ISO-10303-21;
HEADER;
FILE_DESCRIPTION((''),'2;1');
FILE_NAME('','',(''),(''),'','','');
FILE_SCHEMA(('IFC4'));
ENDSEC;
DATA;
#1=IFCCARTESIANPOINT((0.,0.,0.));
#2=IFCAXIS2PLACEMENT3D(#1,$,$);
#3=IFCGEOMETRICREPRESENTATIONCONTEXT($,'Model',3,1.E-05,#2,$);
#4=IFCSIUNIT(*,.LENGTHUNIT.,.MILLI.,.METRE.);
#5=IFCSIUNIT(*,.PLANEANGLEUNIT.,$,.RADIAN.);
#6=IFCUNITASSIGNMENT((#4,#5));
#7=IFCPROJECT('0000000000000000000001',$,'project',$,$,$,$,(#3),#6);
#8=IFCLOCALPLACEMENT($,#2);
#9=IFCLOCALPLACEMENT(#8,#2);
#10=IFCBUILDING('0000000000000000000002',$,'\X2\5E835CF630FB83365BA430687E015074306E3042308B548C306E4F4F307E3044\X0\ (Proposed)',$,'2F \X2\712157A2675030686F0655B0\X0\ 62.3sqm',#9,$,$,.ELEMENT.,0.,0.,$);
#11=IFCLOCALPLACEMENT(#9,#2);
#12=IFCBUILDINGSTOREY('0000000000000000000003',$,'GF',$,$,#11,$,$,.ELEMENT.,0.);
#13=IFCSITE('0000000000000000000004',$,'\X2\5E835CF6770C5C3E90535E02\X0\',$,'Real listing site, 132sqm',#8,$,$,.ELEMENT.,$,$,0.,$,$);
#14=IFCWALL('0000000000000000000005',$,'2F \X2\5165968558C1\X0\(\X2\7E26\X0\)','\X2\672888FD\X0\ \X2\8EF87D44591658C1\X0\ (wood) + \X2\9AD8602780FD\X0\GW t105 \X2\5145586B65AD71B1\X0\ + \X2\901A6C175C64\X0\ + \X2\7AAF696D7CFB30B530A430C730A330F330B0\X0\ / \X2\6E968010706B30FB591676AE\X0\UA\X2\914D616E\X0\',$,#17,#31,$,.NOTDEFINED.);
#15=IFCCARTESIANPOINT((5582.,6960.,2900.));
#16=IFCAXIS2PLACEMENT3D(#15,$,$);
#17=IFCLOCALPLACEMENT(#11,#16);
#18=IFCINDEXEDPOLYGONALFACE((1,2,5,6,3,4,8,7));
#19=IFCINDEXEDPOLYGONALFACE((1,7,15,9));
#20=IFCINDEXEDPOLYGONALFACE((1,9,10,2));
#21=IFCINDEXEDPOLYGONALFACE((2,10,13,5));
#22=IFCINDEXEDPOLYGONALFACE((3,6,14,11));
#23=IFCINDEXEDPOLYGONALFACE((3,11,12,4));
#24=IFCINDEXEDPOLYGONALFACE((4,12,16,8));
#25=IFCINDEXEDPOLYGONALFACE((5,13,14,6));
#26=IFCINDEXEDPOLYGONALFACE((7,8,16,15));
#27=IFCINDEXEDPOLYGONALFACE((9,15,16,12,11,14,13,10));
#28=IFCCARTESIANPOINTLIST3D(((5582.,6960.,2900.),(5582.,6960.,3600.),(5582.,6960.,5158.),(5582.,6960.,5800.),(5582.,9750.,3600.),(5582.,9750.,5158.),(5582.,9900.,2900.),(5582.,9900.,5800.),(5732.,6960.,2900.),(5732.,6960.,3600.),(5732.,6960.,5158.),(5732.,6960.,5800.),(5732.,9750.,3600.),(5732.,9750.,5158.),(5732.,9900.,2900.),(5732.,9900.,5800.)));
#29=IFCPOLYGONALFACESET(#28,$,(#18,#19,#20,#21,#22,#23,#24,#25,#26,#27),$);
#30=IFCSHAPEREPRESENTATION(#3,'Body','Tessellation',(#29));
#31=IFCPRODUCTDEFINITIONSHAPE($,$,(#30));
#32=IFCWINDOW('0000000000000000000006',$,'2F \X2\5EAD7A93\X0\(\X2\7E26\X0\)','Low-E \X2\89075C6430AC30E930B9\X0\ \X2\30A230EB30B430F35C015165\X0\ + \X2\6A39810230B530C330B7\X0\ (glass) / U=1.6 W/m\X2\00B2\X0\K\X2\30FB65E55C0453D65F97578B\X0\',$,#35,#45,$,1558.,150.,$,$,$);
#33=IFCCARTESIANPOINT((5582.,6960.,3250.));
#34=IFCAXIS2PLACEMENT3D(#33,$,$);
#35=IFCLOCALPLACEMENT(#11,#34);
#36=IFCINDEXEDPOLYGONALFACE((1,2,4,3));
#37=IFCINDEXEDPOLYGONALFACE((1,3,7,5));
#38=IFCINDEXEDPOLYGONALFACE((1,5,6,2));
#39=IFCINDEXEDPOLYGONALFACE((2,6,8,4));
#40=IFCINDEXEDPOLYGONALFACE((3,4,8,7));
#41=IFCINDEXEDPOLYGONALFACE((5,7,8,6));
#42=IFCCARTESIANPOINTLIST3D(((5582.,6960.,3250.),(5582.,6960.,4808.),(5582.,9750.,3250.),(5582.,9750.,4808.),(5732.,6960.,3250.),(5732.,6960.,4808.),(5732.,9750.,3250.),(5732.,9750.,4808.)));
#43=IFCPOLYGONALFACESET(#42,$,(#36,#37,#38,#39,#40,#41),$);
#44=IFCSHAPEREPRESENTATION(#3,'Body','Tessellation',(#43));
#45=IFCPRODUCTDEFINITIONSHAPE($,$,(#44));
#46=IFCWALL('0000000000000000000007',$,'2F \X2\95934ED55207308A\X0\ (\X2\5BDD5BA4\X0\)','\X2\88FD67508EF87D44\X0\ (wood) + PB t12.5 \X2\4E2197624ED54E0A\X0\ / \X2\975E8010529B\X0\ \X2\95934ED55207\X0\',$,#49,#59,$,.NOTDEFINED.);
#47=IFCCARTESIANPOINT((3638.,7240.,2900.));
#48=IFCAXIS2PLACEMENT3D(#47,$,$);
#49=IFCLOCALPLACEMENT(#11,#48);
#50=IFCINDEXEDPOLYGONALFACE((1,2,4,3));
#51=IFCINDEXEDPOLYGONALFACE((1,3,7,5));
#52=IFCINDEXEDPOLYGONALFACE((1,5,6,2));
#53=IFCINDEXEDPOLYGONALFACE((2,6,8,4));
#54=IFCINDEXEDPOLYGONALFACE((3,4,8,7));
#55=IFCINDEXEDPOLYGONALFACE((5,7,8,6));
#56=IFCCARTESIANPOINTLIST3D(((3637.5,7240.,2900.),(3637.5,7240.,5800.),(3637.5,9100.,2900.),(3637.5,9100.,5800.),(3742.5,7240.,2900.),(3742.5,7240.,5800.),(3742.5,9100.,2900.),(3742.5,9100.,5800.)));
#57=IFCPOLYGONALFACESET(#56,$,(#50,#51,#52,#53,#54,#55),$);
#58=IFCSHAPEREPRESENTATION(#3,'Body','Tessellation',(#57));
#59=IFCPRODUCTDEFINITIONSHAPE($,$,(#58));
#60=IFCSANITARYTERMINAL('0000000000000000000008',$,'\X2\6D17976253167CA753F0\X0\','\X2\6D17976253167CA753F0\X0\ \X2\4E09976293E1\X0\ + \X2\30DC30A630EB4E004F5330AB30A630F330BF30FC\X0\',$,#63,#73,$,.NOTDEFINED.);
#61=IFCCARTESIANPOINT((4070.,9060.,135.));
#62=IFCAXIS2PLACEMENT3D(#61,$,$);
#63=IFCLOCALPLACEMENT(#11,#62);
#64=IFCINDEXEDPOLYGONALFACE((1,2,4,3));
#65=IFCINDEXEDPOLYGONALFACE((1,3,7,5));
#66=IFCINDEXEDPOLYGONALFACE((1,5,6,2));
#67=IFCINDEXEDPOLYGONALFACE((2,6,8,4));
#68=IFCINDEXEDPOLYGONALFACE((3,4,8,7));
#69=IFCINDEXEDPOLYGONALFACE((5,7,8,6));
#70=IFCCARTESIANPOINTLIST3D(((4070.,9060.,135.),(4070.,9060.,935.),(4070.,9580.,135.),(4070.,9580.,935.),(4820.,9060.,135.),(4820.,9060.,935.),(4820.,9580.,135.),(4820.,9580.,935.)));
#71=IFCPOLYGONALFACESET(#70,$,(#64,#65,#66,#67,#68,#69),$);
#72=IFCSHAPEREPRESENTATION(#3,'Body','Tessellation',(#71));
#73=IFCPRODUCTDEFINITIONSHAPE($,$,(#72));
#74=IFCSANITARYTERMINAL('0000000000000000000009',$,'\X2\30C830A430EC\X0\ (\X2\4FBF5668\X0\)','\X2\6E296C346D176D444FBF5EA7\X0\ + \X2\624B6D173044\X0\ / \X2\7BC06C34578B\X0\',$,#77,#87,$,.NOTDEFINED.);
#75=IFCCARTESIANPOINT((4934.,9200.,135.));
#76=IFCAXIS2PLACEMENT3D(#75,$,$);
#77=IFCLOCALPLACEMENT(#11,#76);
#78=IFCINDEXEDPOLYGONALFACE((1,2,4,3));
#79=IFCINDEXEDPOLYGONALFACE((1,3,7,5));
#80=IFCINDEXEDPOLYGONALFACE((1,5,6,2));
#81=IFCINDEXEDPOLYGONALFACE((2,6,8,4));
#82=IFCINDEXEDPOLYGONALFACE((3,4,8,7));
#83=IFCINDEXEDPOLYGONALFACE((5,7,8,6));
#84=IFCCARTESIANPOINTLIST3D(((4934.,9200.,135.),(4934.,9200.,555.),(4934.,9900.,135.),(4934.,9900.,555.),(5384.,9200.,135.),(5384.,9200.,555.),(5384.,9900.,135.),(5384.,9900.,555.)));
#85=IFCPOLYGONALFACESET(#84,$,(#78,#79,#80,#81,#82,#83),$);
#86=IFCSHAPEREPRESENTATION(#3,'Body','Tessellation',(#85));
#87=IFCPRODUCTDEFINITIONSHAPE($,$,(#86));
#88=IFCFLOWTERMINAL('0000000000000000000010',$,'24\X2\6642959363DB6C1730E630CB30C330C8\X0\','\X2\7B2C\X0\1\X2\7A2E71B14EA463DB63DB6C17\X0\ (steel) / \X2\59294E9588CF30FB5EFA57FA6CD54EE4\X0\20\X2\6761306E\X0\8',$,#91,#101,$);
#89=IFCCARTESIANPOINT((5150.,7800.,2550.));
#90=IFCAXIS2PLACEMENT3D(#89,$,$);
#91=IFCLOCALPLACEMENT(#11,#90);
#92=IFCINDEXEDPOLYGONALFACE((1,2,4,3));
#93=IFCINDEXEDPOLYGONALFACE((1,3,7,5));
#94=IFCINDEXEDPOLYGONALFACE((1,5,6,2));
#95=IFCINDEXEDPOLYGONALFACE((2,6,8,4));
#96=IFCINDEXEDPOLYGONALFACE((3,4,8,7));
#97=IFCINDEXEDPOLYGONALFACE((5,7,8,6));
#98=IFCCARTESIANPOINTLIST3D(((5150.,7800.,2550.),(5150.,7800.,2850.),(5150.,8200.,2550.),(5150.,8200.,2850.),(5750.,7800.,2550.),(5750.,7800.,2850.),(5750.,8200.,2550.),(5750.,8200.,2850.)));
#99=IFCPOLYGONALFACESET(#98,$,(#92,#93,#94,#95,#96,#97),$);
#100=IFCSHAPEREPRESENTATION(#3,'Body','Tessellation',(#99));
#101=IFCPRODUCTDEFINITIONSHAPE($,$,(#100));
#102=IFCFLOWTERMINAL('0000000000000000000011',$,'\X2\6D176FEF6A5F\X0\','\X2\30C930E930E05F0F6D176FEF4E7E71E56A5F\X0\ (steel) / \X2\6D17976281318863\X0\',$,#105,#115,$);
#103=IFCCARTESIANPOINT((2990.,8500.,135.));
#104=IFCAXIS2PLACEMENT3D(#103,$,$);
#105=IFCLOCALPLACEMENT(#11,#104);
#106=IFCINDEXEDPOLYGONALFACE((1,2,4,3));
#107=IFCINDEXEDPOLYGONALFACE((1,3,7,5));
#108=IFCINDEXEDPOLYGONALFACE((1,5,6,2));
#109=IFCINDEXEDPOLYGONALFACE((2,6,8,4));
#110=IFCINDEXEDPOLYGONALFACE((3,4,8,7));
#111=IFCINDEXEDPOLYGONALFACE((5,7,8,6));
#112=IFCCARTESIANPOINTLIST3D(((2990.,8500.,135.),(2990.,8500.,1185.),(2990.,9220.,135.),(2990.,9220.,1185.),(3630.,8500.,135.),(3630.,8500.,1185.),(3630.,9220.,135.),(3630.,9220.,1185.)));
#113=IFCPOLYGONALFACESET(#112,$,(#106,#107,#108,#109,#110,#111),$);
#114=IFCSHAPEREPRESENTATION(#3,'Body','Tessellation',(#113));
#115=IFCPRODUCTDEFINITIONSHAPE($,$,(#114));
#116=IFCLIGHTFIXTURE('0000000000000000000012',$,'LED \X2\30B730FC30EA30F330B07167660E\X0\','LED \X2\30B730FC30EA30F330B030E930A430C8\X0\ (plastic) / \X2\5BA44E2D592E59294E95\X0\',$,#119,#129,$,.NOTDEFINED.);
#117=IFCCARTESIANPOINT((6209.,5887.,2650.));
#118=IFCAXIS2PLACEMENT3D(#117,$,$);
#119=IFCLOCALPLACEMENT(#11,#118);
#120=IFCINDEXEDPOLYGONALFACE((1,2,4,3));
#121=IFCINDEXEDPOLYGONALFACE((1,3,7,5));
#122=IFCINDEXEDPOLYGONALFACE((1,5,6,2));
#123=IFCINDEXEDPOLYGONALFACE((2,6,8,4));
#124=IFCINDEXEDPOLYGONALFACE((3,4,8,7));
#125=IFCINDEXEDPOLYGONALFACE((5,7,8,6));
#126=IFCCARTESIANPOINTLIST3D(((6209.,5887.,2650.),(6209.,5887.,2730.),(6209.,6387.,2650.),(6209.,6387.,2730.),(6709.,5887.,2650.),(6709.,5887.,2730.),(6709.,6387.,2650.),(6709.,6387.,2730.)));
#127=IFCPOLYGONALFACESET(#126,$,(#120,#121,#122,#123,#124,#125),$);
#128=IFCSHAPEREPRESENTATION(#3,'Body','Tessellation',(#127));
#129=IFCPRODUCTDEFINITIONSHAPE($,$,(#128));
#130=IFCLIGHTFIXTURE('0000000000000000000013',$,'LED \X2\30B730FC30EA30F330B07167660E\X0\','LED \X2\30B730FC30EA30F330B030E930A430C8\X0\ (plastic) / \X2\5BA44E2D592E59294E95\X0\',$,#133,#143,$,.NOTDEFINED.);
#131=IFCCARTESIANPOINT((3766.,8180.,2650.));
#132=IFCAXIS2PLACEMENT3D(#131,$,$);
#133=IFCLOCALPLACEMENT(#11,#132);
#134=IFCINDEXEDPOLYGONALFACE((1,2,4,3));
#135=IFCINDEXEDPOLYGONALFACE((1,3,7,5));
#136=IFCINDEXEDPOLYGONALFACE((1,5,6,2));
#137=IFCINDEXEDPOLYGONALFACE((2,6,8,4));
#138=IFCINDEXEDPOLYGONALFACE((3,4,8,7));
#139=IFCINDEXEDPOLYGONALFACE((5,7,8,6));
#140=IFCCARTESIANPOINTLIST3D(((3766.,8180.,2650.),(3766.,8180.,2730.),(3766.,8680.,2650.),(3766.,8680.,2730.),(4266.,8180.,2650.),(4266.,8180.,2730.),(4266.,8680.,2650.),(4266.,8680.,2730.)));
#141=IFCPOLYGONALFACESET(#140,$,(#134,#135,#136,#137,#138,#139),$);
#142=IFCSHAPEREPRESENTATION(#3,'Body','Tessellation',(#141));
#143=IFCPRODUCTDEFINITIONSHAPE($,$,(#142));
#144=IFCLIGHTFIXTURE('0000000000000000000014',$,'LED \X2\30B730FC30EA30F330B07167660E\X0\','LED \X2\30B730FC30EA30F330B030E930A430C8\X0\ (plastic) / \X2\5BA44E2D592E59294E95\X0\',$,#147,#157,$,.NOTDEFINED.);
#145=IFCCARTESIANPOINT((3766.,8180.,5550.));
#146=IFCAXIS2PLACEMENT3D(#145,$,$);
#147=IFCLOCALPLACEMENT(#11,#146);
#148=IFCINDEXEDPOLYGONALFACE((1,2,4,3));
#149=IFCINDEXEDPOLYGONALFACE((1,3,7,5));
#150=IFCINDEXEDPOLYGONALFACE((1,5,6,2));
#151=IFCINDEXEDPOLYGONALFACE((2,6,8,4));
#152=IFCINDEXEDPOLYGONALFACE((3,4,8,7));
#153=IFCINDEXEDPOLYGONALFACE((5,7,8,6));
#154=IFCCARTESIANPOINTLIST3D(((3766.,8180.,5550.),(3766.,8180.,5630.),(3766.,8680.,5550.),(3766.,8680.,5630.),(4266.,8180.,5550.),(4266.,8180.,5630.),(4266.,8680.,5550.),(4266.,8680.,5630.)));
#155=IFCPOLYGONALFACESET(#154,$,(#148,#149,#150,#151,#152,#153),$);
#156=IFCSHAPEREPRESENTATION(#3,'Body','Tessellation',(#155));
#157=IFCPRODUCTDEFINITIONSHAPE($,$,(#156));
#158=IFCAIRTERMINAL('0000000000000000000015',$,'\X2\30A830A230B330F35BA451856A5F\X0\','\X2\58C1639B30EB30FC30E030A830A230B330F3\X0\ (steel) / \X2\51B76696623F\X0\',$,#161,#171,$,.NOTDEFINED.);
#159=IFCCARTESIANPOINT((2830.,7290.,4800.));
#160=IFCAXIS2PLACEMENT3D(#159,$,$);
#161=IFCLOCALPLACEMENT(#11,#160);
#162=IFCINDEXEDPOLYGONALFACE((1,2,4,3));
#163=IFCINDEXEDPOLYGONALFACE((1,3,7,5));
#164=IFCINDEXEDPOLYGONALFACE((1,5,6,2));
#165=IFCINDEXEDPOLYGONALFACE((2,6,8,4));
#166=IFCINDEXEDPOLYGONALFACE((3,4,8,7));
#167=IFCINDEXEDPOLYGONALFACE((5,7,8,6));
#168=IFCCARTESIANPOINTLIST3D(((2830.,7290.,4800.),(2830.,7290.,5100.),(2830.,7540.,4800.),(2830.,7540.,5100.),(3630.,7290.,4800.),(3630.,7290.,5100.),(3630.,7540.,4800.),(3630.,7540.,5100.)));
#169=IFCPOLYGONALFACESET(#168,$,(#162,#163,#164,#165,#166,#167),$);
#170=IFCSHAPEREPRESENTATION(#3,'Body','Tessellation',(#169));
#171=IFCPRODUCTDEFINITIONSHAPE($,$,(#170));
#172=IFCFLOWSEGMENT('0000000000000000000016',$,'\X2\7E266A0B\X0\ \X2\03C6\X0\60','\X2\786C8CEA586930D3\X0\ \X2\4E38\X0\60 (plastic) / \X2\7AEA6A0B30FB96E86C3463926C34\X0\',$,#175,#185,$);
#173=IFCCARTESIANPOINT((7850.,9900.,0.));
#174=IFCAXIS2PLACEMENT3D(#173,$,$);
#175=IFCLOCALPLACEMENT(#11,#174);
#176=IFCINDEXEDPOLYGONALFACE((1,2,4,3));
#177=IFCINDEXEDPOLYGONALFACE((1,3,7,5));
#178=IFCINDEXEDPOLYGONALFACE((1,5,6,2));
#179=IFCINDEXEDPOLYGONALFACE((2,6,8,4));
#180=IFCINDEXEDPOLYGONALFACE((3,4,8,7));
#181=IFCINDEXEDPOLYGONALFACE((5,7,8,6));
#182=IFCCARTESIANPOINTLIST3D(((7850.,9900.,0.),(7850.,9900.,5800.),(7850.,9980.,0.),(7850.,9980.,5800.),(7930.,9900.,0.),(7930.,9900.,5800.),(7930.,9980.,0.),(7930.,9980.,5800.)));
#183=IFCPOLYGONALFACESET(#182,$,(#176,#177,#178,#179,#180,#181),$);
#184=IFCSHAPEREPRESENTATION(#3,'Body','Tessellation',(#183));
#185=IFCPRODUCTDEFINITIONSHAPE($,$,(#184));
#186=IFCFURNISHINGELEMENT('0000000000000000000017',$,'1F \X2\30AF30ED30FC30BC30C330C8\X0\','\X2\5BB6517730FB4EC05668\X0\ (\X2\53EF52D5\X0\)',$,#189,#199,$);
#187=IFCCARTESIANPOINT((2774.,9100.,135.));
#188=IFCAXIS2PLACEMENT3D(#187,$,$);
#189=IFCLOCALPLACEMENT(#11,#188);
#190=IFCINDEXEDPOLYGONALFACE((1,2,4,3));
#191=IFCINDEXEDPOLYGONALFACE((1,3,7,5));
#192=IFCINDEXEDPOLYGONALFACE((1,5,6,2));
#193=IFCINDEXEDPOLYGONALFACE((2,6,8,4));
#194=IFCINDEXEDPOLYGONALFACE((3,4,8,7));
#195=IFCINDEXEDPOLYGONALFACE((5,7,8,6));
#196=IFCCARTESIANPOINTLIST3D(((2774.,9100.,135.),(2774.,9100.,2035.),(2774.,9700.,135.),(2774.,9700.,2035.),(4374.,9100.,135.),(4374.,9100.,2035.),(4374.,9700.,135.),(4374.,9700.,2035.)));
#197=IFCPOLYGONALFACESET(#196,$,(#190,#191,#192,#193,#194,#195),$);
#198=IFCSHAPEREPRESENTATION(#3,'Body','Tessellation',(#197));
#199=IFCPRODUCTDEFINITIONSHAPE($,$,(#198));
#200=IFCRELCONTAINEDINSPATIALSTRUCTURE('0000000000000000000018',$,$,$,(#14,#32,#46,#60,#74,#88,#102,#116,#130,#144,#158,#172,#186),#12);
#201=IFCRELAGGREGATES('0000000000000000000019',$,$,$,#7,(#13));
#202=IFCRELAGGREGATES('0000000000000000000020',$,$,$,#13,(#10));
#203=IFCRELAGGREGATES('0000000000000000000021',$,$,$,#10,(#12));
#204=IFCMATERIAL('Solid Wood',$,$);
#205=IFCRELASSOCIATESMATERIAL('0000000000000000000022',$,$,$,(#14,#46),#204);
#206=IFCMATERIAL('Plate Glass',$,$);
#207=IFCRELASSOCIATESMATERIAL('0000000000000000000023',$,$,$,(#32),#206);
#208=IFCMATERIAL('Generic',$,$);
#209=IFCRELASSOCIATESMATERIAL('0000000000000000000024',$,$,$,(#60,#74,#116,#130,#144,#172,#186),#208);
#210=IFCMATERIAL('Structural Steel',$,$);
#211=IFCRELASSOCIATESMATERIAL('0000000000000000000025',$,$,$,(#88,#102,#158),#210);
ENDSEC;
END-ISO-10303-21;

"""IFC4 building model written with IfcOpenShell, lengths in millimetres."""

from ifc_helpers import new_model, si_unit, frame, frame_2d, origin, place, context, project, spatial, rectangle, extrude, material, element, fill, save


model = new_model("IFC4")

# Units and contexts
model_context = context("Model", 3, precision=1e-05, world=origin())
ifc_project = project(units=[si_unit("LENGTHUNIT", "METRE", prefix="MILLI"), si_unit("PLANEANGLEUNIT", "RADIAN")], contexts=[model_context])

# Site, building, storey
site_placement = place(None, origin())
site = spatial("IfcSite", under=ifc_project, at=site_placement, Name="広島県尾道市", ObjectType="Real listing site, 132sqm", CompositionType="ELEMENT", RefElevation=0.0)
building_placement = place(site_placement, origin())
building = spatial("IfcBuilding", under=site, at=building_placement, Name="広島・茶室と縁側のある和の住まい (Proposed)", ObjectType="2F 無垢材と漆喰 62.3sqm", CompositionType="ELEMENT", ElevationOfRefHeight=0.0, ElevationOfTerrain=0.0)
storey_placement = place(building_placement, origin())
storey = spatial("IfcBuildingStorey", under=building, at=storey_placement, Name="GF", CompositionType="ELEMENT", Elevation=0.0)

# Shared definitions
ifc_material_1 = material(Name="Solid Wood")

# Shared definitions
ifc_material_2 = material(Name="Plate Glass")

# Wall, opening, window
wall_1_placement = place(storey_placement, frame((5582.0, 6960.0, 2900.0)))
wall_1 = element("IfcWall", 1, at=wall_1_placement, inside=storey, material=ifc_material_1, Name="2F 入隅壁(縦)", Description="木製 軸組外壁 (wood) + 高性能GW t105 充填断熱 + 通気層 + 窯業系サイディング / 準耐火・外皮UA配慮", PredefinedType="NOTDEFINED", context=model_context, shape_type="SweptSolid", body=[
    extrude(rectangle(XDim=150.0, YDim=2940.0, at=frame_2d((75.0, 1470.0))), frame((5582.0, 6960.0, 2900.0)), (0.0, 0.0, 1.0), 2900.0),
])
opening_1_placement = place(storey_placement, frame((5582.0, 6960.0, 3250.0)))
opening_1 = element("IfcOpeningElement", 2, at=opening_1_placement, cuts=wall_1, PredefinedType="NOTDEFINED", context=model_context, shape_type="SweptSolid", body=[
    extrude(rectangle(XDim=150.0, YDim=2790.0, at=frame_2d((75.0, 1395.0))), frame((5582.0, 6960.0, 3250.0)), (0.0, 0.0, 1.0), 1558.0),
])
window_1_placement = place(storey_placement, frame((5582.0, 6960.0, 3250.0)))
window_1 = element("IfcWindow", 3, at=window_1_placement, inside=storey, material=ifc_material_2, Name="2F 庭窓(縦)", Description="Low-E 複層ガラス アルゴン封入 + 樹脂サッシ (glass) / U=1.6 W/m²K・日射取得型", OverallHeight=1558.0, OverallWidth=150.0, context=model_context, shape_type="SweptSolid", body=[
    extrude(rectangle(XDim=150.0, YDim=2790.0, at=frame_2d((75.0, 1395.0))), frame((5582.0, 6960.0, 3250.0)), (0.0, 0.0, 1.0), 1558.0),
])
fill(opening_1, window_1)

# Wall
wall_2_placement = place(storey_placement, frame((3638.0, 7240.0, 2900.0)))
element("IfcWall", 4, at=wall_2_placement, inside=storey, material=ifc_material_1, Name="2F 間仕切り (寝室)", Description="製材軸組 (wood) + PB t12.5 両面仕上 / 非耐力 間仕切", PredefinedType="NOTDEFINED", context=model_context, shape_type="SweptSolid", body=[
    extrude(rectangle(XDim=105.0, YDim=1860.0, at=frame_2d((52.0, 930.0))), frame((3638.0, 7240.0, 2900.0)), (0.0, 0.0, 1.0), 2900.0),
])

# Sanitary terminals
ifc_material_3 = material(Name="Generic")
sanitary_terminal_1_placement = place(storey_placement, frame((4070.0, 9060.0, 135.0)))
element("IfcSanitaryTerminal", 5, at=sanitary_terminal_1_placement, inside=storey, material=ifc_material_3, Name="洗面化粧台", Description="洗面化粧台 三面鏡 + ボウル一体カウンター", PredefinedType="NOTDEFINED", context=model_context, shape_type="SweptSolid", body=[
    extrude(rectangle(XDim=750.0, YDim=520.0, at=frame_2d((375.0, 260.0))), frame((4070.0, 9060.0, 135.0)), (0.0, 0.0, 1.0), 800.0),
])
sanitary_terminal_2_placement = place(storey_placement, frame((4934.0, 9200.0, 135.0)))
element("IfcSanitaryTerminal", 6, at=sanitary_terminal_2_placement, inside=storey, material=ifc_material_3, Name="トイレ (便器)", Description="温水洗浄便座 + 手洗い / 節水型", PredefinedType="NOTDEFINED", context=model_context, shape_type="SweptSolid", body=[
    extrude(rectangle(XDim=450.0, YDim=700.0, at=frame_2d((225.0, 350.0))), frame((4934.0, 9200.0, 135.0)), (0.0, 0.0, 1.0), 420.0),
])

# Flow terminals
ifc_material_4 = material(Name="Structural Steel")
flow_terminal_1_placement = place(storey_placement, frame((5150.0, 7800.0, 2550.0)))
element("IfcFlowTerminal", 7, at=flow_terminal_1_placement, inside=storey, material=ifc_material_4, Name="24時間換気ユニット", Description="第1種熱交換換気 (steel) / 天井裏・建基法令20条の8", context=model_context, shape_type="SweptSolid", body=[
    extrude(rectangle(XDim=600.0, YDim=400.0, at=frame_2d((300.0, 200.0))), frame((5150.0, 7800.0, 2550.0)), (0.0, 0.0, 1.0), 300.0),
])
flow_terminal_2_placement = place(storey_placement, frame((2990.0, 8500.0, 135.0)))
element("IfcFlowTerminal", 8, at=flow_terminal_2_placement, inside=storey, material=ifc_material_4, Name="洗濯機", Description="ドラム式洗濯乾燥機 (steel) / 洗面脱衣", context=model_context, shape_type="SweptSolid", body=[
    extrude(rectangle(XDim=640.0, YDim=720.0, at=frame_2d((320.0, 360.0))), frame((2990.0, 8500.0, 135.0)), (0.0, 0.0, 1.0), 1050.0),
])

# Light fixtures
light_fixture_1_placement = place(storey_placement, frame((6209.0, 5887.0, 2650.0)))
element("IfcLightFixture", 9, at=light_fixture_1_placement, inside=storey, material=ifc_material_3, Name="LED シーリング照明", Description="LED シーリングライト (plastic) / 室中央天井", PredefinedType="NOTDEFINED", context=model_context, shape_type="SweptSolid", body=[
    extrude(rectangle(XDim=500.0, YDim=500.0, at=frame_2d((250.0, 250.0))), frame((6209.0, 5887.0, 2650.0)), (0.0, 0.0, 1.0), 80.0),
])
light_fixture_2_placement = place(storey_placement, frame((3766.0, 8180.0, 2650.0)))
element("IfcLightFixture", 10, at=light_fixture_2_placement, inside=storey, material=ifc_material_3, Name="LED シーリング照明", Description="LED シーリングライト (plastic) / 室中央天井", PredefinedType="NOTDEFINED", context=model_context, shape_type="SweptSolid", body=[
    extrude(rectangle(XDim=500.0, YDim=500.0, at=frame_2d((250.0, 250.0))), frame((3766.0, 8180.0, 2650.0)), (0.0, 0.0, 1.0), 80.0),
])
light_fixture_3_placement = place(storey_placement, frame((3766.0, 8180.0, 5550.0)))
element("IfcLightFixture", 11, at=light_fixture_3_placement, inside=storey, material=ifc_material_3, Name="LED シーリング照明", Description="LED シーリングライト (plastic) / 室中央天井", PredefinedType="NOTDEFINED", context=model_context, shape_type="SweptSolid", body=[
    extrude(rectangle(XDim=500.0, YDim=500.0, at=frame_2d((250.0, 250.0))), frame((3766.0, 8180.0, 5550.0)), (0.0, 0.0, 1.0), 80.0),
])

# Air terminal
air_terminal_placement = place(storey_placement, frame((2830.0, 7290.0, 4800.0)))
element("IfcAirTerminal", 12, at=air_terminal_placement, inside=storey, material=ifc_material_4, Name="エアコン室内機", Description="壁掛ルームエアコン (steel) / 冷暖房", PredefinedType="NOTDEFINED", context=model_context, shape_type="SweptSolid", body=[
    extrude(rectangle(XDim=800.0, YDim=250.0, at=frame_2d((400.0, 125.0))), frame((2830.0, 7290.0, 4800.0)), (0.0, 0.0, 1.0), 300.0),
])

# Flow segment
flow_segment_placement = place(storey_placement, frame((7850.0, 9900.0, 0.0)))
element("IfcFlowSegment", 13, at=flow_segment_placement, inside=storey, material=ifc_material_3, Name="縦樋 φ60", Description="硬質塩ビ 丸60 (plastic) / 竪樋・雨水排水", context=model_context, shape_type="SweptSolid", body=[
    extrude(rectangle(XDim=80.0, YDim=80.0, at=frame_2d((40.0, 40.0))), frame((7850.0, 9900.0, 0.0)), (0.0, 0.0, 1.0), 5800.0),
])

# Furnishing element
furnishing_1_placement = place(storey_placement, frame((2774.0, 9100.0, 135.0)))
element("IfcFurnishingElement", 14, at=furnishing_1_placement, inside=storey, material=ifc_material_3, Name="1F クローゼット", Description="家具・什器 (可動)", context=model_context, shape_type="SweptSolid", body=[
    extrude(rectangle(XDim=1600.0, YDim=600.0, at=frame_2d((800.0, 300.0))), frame((2774.0, 9100.0, 135.0)), (0.0, 0.0, 1.0), 1900.0),
])

save(model, "model.ifc")
